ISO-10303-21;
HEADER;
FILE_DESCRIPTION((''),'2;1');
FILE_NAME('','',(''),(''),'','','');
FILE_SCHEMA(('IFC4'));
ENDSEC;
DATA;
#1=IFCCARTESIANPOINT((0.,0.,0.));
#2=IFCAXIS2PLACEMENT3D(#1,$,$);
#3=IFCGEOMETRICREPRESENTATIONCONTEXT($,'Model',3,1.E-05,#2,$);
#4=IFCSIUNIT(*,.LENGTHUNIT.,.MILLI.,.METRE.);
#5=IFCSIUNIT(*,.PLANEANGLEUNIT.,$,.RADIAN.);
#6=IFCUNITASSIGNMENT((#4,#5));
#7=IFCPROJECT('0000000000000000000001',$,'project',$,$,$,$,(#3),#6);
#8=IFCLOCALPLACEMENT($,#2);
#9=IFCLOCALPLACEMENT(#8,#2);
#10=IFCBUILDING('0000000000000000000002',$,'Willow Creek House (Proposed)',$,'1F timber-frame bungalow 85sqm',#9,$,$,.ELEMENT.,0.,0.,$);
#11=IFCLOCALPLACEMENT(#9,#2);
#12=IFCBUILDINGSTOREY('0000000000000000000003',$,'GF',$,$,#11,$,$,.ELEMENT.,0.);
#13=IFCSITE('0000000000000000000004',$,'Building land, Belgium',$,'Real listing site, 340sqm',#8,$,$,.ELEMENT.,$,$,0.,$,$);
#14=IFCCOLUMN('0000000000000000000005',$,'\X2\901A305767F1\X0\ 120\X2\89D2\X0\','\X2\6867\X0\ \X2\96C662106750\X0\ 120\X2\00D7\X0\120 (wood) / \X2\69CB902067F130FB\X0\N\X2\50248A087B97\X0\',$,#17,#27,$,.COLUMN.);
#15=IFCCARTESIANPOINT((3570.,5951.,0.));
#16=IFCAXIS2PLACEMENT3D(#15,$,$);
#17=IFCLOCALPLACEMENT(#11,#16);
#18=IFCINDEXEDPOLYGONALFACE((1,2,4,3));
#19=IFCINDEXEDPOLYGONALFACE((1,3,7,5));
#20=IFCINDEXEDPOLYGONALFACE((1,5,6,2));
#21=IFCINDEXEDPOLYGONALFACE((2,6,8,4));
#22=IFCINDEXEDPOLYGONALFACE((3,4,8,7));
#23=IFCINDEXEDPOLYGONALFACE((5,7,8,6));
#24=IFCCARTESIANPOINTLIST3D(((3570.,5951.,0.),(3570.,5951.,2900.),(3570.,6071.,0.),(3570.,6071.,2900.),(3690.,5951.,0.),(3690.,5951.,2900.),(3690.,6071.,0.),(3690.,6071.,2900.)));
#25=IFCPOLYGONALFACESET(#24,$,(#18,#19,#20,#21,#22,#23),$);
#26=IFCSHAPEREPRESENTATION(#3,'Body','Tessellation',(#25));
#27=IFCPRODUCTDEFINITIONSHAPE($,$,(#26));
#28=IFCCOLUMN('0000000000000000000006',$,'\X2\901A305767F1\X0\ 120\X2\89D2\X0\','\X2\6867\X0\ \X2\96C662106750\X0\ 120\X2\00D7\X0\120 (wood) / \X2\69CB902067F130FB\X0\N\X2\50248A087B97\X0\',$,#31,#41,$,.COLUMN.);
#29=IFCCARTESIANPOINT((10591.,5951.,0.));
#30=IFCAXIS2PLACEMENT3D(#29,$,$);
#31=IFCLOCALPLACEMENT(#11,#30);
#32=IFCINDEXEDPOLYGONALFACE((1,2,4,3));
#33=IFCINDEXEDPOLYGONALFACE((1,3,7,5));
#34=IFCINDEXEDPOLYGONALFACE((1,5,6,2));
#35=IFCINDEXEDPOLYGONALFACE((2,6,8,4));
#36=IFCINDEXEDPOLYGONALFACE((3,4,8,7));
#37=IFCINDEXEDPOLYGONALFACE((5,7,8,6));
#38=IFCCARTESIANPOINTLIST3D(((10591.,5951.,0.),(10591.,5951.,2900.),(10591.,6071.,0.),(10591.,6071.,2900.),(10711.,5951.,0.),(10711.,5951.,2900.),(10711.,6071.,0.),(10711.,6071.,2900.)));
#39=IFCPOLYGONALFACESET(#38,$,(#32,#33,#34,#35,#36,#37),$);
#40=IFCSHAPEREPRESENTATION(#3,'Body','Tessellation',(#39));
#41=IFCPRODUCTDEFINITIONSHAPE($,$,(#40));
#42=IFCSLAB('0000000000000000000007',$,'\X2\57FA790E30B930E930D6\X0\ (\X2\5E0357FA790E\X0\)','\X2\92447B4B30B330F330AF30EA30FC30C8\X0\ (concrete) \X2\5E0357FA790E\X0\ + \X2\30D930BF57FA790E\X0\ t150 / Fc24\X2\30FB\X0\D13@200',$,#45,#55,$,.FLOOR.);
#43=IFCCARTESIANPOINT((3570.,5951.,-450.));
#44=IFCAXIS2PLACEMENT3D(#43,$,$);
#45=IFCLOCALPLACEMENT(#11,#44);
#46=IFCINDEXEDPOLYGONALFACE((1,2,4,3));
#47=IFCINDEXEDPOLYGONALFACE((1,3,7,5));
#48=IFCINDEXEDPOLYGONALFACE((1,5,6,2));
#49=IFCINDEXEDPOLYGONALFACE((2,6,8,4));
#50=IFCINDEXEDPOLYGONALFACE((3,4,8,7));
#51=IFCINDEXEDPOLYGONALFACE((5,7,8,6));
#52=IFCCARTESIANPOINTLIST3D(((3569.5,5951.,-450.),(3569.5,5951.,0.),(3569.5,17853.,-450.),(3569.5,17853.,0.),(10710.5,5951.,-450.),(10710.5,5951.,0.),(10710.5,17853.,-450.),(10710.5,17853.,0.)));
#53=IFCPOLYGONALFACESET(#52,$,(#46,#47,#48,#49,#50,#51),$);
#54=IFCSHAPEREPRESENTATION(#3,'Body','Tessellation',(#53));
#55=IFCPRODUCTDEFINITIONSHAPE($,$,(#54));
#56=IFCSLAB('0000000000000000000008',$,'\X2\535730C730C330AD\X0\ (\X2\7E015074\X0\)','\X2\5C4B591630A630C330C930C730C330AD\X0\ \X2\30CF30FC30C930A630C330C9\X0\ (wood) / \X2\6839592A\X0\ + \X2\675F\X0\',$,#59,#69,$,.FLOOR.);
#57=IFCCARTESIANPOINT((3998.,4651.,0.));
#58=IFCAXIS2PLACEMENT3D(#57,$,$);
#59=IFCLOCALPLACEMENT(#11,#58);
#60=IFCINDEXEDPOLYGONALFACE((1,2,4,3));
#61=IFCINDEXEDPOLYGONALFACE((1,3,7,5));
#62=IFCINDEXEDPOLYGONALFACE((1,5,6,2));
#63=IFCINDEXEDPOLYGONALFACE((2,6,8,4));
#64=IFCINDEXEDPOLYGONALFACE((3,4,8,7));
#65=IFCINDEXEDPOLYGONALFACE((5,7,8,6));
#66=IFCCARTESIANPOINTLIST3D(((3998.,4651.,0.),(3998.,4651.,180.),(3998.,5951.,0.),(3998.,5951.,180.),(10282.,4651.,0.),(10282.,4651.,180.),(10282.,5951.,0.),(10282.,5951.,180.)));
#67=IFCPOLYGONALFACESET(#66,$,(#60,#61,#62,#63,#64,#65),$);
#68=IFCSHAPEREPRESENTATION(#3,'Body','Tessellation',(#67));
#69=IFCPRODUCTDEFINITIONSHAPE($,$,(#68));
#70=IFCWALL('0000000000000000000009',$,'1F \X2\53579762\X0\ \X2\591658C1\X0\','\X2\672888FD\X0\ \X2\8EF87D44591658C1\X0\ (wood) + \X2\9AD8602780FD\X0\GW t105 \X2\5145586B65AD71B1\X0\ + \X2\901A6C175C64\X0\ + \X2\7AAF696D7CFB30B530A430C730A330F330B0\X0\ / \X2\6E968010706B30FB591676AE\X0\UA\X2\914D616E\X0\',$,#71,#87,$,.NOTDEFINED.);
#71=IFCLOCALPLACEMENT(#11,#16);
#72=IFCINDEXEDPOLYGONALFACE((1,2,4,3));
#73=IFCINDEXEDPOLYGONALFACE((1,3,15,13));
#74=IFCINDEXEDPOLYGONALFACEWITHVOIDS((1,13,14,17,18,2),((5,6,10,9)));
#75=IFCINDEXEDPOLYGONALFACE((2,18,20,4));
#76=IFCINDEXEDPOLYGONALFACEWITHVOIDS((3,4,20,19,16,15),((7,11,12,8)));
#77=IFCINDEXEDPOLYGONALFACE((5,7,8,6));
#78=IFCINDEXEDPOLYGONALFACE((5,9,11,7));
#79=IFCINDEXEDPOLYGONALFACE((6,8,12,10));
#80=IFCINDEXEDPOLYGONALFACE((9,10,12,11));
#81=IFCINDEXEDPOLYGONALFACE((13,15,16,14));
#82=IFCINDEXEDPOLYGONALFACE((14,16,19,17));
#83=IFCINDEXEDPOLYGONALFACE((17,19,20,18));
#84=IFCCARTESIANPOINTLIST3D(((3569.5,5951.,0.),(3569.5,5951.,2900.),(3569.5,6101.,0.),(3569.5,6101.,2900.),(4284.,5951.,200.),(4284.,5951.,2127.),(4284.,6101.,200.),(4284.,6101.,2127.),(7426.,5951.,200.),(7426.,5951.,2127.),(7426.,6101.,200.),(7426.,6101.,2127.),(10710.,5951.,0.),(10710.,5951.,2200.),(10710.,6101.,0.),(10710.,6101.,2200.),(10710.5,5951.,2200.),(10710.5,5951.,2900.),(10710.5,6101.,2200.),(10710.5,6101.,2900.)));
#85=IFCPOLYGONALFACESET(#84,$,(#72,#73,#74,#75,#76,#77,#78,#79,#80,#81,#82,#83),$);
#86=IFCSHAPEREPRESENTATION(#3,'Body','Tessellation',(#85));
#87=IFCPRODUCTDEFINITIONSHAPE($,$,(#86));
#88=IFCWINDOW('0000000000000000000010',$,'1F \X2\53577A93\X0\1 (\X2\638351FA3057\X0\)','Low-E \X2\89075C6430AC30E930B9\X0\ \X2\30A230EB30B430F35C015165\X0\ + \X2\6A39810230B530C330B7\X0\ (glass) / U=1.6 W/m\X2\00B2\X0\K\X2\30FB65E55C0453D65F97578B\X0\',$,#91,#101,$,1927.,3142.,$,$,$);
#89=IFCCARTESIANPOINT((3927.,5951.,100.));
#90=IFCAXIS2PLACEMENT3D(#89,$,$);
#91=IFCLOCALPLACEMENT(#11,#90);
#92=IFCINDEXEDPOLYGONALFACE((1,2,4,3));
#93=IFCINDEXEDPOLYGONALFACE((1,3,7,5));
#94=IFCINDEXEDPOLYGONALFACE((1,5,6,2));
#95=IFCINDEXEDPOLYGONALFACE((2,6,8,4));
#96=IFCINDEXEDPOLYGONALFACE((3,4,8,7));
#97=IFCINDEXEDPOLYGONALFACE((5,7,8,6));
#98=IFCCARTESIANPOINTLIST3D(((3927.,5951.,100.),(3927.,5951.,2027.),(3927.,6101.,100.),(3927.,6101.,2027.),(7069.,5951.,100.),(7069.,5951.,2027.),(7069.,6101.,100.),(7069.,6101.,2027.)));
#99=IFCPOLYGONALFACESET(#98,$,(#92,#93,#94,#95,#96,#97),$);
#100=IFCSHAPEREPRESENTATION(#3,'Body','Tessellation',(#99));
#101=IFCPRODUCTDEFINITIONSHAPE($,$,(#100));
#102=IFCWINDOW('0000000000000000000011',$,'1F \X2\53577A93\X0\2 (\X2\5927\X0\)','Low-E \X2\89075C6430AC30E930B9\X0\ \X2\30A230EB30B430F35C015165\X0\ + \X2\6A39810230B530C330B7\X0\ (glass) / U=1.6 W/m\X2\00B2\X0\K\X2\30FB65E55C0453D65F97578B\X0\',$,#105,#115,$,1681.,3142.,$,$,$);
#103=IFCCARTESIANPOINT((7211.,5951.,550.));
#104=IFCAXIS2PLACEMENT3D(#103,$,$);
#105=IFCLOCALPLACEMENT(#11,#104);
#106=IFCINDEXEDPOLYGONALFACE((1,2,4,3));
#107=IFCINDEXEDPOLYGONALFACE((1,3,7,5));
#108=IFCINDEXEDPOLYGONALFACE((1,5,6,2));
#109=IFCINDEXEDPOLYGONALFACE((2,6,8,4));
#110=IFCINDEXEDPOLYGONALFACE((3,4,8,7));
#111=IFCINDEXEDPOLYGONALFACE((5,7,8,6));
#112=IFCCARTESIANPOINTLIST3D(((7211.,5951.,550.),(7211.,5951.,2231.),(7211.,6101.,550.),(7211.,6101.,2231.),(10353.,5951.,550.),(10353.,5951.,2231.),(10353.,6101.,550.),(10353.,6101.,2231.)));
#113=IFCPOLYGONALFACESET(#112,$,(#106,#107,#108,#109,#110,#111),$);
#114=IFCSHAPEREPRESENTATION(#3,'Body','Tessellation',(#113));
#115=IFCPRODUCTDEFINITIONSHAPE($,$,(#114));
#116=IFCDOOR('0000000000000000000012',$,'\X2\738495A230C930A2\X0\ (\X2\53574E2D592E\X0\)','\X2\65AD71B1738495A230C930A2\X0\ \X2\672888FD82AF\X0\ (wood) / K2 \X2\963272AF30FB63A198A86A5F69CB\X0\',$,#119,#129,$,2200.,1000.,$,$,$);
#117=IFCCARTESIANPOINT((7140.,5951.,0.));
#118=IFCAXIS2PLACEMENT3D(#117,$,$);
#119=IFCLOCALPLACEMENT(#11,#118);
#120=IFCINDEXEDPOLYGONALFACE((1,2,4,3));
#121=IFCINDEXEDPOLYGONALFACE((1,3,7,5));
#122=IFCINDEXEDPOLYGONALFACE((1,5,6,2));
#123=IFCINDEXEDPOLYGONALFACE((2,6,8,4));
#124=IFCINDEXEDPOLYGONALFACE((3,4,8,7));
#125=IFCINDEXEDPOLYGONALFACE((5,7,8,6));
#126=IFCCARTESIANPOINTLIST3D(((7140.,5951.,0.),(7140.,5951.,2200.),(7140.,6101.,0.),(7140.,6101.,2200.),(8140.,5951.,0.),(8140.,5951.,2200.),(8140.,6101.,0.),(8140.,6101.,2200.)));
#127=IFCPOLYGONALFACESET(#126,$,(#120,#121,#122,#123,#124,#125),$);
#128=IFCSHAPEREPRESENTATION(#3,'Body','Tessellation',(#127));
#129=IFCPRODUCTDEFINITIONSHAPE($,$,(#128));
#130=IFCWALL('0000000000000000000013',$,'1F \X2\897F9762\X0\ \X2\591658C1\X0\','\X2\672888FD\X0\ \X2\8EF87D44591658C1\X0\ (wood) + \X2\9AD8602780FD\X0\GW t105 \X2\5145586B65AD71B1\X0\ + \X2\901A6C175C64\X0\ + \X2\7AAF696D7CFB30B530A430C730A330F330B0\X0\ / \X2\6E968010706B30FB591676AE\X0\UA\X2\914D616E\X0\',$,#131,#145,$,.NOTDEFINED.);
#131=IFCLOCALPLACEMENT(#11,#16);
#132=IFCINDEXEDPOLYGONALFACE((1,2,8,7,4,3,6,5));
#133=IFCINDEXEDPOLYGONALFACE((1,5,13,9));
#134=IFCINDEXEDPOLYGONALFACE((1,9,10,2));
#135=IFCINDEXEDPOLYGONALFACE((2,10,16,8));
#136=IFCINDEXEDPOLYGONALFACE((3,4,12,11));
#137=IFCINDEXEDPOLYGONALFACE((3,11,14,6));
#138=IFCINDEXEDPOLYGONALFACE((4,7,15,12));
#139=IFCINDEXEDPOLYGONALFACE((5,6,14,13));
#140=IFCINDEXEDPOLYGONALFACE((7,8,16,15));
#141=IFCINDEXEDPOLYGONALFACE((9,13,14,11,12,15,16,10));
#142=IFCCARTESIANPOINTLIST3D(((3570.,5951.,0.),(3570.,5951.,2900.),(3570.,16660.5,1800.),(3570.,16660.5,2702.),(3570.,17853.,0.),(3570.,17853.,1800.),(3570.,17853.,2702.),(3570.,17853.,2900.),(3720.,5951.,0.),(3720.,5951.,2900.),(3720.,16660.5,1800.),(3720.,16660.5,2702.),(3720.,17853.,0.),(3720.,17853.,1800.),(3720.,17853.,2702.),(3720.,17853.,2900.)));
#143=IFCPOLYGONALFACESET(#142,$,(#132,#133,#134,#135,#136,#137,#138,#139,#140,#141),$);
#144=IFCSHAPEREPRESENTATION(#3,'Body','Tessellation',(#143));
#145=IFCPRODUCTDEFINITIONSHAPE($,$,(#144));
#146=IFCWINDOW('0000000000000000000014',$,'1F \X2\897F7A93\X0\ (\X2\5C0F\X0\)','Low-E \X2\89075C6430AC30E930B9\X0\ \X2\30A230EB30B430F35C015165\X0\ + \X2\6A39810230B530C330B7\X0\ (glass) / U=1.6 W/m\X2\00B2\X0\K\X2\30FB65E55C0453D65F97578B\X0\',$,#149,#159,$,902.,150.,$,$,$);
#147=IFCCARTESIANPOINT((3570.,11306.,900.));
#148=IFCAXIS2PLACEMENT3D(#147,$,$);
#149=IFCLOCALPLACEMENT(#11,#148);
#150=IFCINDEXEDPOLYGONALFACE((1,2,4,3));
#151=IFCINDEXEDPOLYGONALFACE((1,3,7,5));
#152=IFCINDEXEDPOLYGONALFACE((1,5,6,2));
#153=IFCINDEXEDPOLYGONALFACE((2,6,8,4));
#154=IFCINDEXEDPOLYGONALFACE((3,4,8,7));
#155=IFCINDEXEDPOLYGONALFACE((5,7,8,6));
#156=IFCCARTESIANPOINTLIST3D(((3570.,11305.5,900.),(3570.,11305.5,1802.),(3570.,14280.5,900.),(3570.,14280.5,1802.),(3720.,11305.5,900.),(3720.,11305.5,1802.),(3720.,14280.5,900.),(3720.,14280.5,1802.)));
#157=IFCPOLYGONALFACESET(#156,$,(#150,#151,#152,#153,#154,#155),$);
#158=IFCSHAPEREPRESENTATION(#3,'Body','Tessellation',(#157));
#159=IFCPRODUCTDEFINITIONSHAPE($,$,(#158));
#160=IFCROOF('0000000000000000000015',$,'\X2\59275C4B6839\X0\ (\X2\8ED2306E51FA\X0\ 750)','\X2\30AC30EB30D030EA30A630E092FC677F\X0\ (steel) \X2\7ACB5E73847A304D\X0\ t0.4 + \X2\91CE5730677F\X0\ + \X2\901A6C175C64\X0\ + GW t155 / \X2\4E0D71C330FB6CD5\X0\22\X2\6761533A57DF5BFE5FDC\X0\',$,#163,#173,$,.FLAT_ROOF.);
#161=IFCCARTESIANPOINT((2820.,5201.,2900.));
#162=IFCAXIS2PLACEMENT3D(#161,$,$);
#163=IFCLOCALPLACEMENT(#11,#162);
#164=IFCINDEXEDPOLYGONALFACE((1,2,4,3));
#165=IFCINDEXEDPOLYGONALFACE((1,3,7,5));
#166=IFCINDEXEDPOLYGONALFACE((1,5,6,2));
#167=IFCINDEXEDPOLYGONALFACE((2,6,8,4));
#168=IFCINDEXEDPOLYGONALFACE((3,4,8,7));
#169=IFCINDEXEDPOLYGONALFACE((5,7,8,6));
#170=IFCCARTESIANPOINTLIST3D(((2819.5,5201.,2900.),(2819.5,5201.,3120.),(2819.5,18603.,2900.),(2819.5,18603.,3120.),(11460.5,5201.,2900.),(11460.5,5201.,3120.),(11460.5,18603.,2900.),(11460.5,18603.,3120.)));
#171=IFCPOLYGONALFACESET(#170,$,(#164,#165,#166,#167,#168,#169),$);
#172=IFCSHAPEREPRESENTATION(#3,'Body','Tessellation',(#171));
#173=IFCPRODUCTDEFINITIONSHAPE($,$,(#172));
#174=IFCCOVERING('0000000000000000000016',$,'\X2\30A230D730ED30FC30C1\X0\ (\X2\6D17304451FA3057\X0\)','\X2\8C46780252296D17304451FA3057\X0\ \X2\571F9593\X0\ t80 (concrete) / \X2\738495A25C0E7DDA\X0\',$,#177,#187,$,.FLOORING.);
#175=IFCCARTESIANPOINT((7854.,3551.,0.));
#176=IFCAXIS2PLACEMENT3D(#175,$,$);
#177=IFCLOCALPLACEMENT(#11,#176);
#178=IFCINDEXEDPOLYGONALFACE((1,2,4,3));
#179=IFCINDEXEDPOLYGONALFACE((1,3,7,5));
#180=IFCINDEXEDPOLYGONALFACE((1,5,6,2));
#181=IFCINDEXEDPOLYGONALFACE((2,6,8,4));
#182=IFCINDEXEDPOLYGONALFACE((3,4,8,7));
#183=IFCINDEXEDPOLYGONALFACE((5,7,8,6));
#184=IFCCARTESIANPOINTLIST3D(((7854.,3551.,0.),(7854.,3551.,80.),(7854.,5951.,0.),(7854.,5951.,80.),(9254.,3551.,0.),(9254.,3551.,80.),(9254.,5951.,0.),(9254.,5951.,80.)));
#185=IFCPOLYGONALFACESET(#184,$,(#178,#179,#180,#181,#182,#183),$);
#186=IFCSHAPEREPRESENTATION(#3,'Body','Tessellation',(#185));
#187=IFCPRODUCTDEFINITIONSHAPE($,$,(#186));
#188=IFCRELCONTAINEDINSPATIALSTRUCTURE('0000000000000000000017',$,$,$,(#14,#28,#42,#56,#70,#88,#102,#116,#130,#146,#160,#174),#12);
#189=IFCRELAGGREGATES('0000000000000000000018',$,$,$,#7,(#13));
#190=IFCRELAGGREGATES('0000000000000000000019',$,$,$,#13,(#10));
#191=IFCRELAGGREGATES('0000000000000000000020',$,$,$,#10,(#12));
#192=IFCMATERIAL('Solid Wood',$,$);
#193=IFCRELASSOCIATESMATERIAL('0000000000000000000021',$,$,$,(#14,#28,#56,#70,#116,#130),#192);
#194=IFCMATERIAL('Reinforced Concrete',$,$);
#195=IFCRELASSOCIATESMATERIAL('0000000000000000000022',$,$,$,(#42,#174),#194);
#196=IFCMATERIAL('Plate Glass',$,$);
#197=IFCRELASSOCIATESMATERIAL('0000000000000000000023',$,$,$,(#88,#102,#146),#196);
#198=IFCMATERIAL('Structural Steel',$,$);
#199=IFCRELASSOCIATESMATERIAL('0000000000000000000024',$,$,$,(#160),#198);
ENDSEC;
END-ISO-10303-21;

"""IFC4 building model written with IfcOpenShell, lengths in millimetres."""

from ifc_helpers import new_model, si_unit, frame, frame_2d, origin, place, context, project, spatial, rectangle, extrude, material, element, fill, save


model = new_model("IFC4")

# Units and contexts
model_context = context("Model", 3, precision=1e-05, world=origin())
ifc_project = project(units=[si_unit("LENGTHUNIT", "METRE", prefix="MILLI"), si_unit("PLANEANGLEUNIT", "RADIAN")], contexts=[model_context])

# Site, building, storey
site_placement = place(None, origin())
site = spatial("IfcSite", under=ifc_project, at=site_placement, Name="Building land, Belgium", ObjectType="Real listing site, 340sqm", CompositionType="ELEMENT", RefElevation=0.0)
building_placement = place(site_placement, origin())
building = spatial("IfcBuilding", under=site, at=building_placement, Name="Willow Creek House (Proposed)", ObjectType="1F timber-frame bungalow 85sqm", CompositionType="ELEMENT", ElevationOfRefHeight=0.0, ElevationOfTerrain=0.0)
storey_placement = place(building_placement, origin())
storey = spatial("IfcBuildingStorey", under=building, at=storey_placement, Name="GF", CompositionType="ELEMENT", Elevation=0.0)

# Columns
ifc_material_1 = material(Name="Solid Wood")
column_1_placement = place(storey_placement, frame((3570.0, 5951.0, 0.0)))
element("IfcColumn", 1, at=column_1_placement, inside=storey, material=ifc_material_1, Name="通し柱 120角", Description="桧 集成材 120×120 (wood) / 構造柱・N値計算", PredefinedType="COLUMN", context=model_context, shape_type="SweptSolid", body=[
    extrude(rectangle(XDim=120.0, YDim=120.0, at=frame_2d((60.0, 60.0))), frame((3570.0, 5951.0, 0.0)), (0.0, 0.0, 1.0), 2900.0),
])
column_2_placement = place(storey_placement, frame((10591.0, 5951.0, 0.0)))
element("IfcColumn", 2, at=column_2_placement, inside=storey, material=ifc_material_1, Name="通し柱 120角", Description="桧 集成材 120×120 (wood) / 構造柱・N値計算", PredefinedType="COLUMN", context=model_context, shape_type="SweptSolid", body=[
    extrude(rectangle(XDim=120.0, YDim=120.0, at=frame_2d((60.0, 60.0))), frame((10591.0, 5951.0, 0.0)), (0.0, 0.0, 1.0), 2900.0),
])

# Slabs
ifc_material_2 = material(Name="Reinforced Concrete")
slab_1_placement = place(storey_placement, frame((3570.0, 5951.0, -450.0)))
element("IfcSlab", 3, at=slab_1_placement, inside=storey, material=ifc_material_2, Name="基礎スラブ (布基礎)", Description="鉄筋コンクリート (concrete) 布基礎 + ベタ基礎 t150 / Fc24・D13@200", PredefinedType="FLOOR", context=model_context, shape_type="SweptSolid", body=[
    extrude(rectangle(XDim=7141.0, YDim=11902.0, at=frame_2d((3570.0, 5951.0))), frame((3570.0, 5951.0, -450.0)), (0.0, 0.0, 1.0), 450.0),
])
slab_2_placement = place(storey_placement, frame((3998.0, 4651.0, 0.0)))
element("IfcSlab", 4, at=slab_2_placement, inside=storey, material=ifc_material_1, Name="南デッキ (縁側)", Description="屋外ウッドデッキ ハードウッド (wood) / 根太 + 束", PredefinedType="FLOOR", context=model_context, shape_type="SweptSolid", body=[
    extrude(rectangle(XDim=6284.0, YDim=1300.0, at=frame_2d((3142.0, 650.0))), frame((3998.0, 4651.0, 0.0)), (0.0, 0.0, 1.0), 180.0),
])

# Wall, openings, windows, door
wall_1_placement = place(storey_placement, frame((3570.0, 5951.0, 0.0)))
wall_1 = element("IfcWall", 5, at=wall_1_placement, inside=storey, material=ifc_material_1, Name="1F 南面 外壁", Description="木製 軸組外壁 (wood) + 高性能GW t105 充填断熱 + 通気層 + 窯業系サイディング / 準耐火・外皮UA配慮", PredefinedType="NOTDEFINED", context=model_context, shape_type="SweptSolid", body=[
    extrude(rectangle(XDim=7141.0, YDim=150.0, at=frame_2d((3570.0, 75.0))), frame((3570.0, 5951.0, 0.0)), (0.0, 0.0, 1.0), 2900.0),
])
opening_1_placement = place(storey_placement, frame((3927.0, 5951.0, 100.0)))
opening_1 = element("IfcOpeningElement", 6, at=opening_1_placement, cuts=wall_1, PredefinedType="NOTDEFINED", context=model_context, shape_type="SweptSolid", body=[
    extrude(rectangle(XDim=3142.0, YDim=150.0, at=frame_2d((1571.0, 75.0))), frame((3927.0, 5951.0, 100.0)), (0.0, 0.0, 1.0), 1927.0),
])
opening_2_placement = place(storey_placement, frame((7211.0, 5951.0, 550.0)))
opening_2 = element("IfcOpeningElement", 7, at=opening_2_placement, cuts=wall_1, PredefinedType="NOTDEFINED", context=model_context, shape_type="SweptSolid", body=[
    extrude(rectangle(XDim=3142.0, YDim=150.0, at=frame_2d((1571.0, 75.0))), frame((7211.0, 5951.0, 550.0)), (0.0, 0.0, 1.0), 1681.0),
])
opening_3_placement = place(storey_placement, frame((7140.0, 5951.0, 0.0)))
opening_3 = element("IfcOpeningElement", 8, at=opening_3_placement, cuts=wall_1, PredefinedType="NOTDEFINED", context=model_context, shape_type="SweptSolid", body=[
    extrude(rectangle(XDim=1000.0, YDim=150.0, at=frame_2d((500.0, 75.0))), frame((7140.0, 5951.0, 0.0)), (0.0, 0.0, 1.0), 2200.0),
])
ifc_material_3 = material(Name="Plate Glass")
window_1_placement = place(storey_placement, frame((3927.0, 5951.0, 100.0)))
window_1 = element("IfcWindow", 9, at=window_1_placement, inside=storey, material=ifc_material_3, Name="1F 南窓1 (掃出し)", Description="Low-E 複層ガラス アルゴン封入 + 樹脂サッシ (glass) / U=1.6 W/m²K・日射取得型", OverallHeight=1927.0, OverallWidth=3142.0, context=model_context, shape_type="SweptSolid", body=[
    extrude(rectangle(XDim=3142.0, YDim=150.0, at=frame_2d((1571.0, 75.0))), frame((3927.0, 5951.0, 100.0)), (0.0, 0.0, 1.0), 1927.0),
])
fill(opening_1, window_1)
window_2_placement = place(storey_placement, frame((7211.0, 5951.0, 550.0)))
window_2 = element("IfcWindow", 10, at=window_2_placement, inside=storey, material=ifc_material_3, Name="1F 南窓2 (大)", Description="Low-E 複層ガラス アルゴン封入 + 樹脂サッシ (glass) / U=1.6 W/m²K・日射取得型", OverallHeight=1681.0, OverallWidth=3142.0, context=model_context, shape_type="SweptSolid", body=[
    extrude(rectangle(XDim=3142.0, YDim=150.0, at=frame_2d((1571.0, 75.0))), frame((7211.0, 5951.0, 550.0)), (0.0, 0.0, 1.0), 1681.0),
])
fill(opening_2, window_2)
door_placement = place(storey_placement, frame((7140.0, 5951.0, 0.0)))
door = element("IfcDoor", 11, at=door_placement, inside=storey, material=ifc_material_1, Name="玄関ドア (南中央)", Description="断熱玄関ドア 木製芯 (wood) / K2 防犯・採風機構", OverallHeight=2200.0, OverallWidth=1000.0, context=model_context, shape_type="SweptSolid", body=[
    extrude(rectangle(XDim=1000.0, YDim=150.0, at=frame_2d((500.0, 75.0))), frame((7140.0, 5951.0, 0.0)), (0.0, 0.0, 1.0), 2200.0),
])
fill(opening_3, door)

# Wall, opening, window
wall_2_placement = place(storey_placement, frame((3570.0, 5951.0, 0.0)))
wall_2 = element("IfcWall", 12, at=wall_2_placement, inside=storey, material=ifc_material_1, Name="1F 西面 外壁", Description="木製 軸組外壁 (wood) + 高性能GW t105 充填断熱 + 通気層 + 窯業系サイディング / 準耐火・外皮UA配慮", PredefinedType="NOTDEFINED", context=model_context, shape_type="SweptSolid", body=[
    extrude(rectangle(XDim=150.0, YDim=11902.0, at=frame_2d((75.0, 5951.0))), frame((3570.0, 5951.0, 0.0)), (0.0, 0.0, 1.0), 2900.0),
])
opening_4_placement = place(storey_placement, frame((3570.0, 11306.0, 900.0)))
opening_4 = element("IfcOpeningElement", 13, at=opening_4_placement, cuts=wall_2, PredefinedType="NOTDEFINED", context=model_context, shape_type="SweptSolid", body=[
    extrude(rectangle(XDim=150.0, YDim=2975.0, at=frame_2d((75.0, 1487.0))), frame((3570.0, 11306.0, 900.0)), (0.0, 0.0, 1.0), 902.0),
])
window_3_placement = place(storey_placement, frame((3570.0, 11306.0, 900.0)))
window_3 = element("IfcWindow", 14, at=window_3_placement, inside=storey, material=ifc_material_3, Name="1F 西窓 (小)", Description="Low-E 複層ガラス アルゴン封入 + 樹脂サッシ (glass) / U=1.6 W/m²K・日射取得型", OverallHeight=902.0, OverallWidth=150.0, context=model_context, shape_type="SweptSolid", body=[
    extrude(rectangle(XDim=150.0, YDim=2975.0, at=frame_2d((75.0, 1487.0))), frame((3570.0, 11306.0, 900.0)), (0.0, 0.0, 1.0), 902.0),
])
fill(opening_4, window_3)

# Roof
ifc_material_4 = material(Name="Structural Steel")
roof_placement = place(storey_placement, frame((2820.0, 5201.0, 2900.0)))
element("IfcRoof", 15, at=roof_placement, inside=storey, material=ifc_material_4, Name="大屋根 (軒の出 750)", Description="ガルバリウム鋼板 (steel) 立平葺き t0.4 + 野地板 + 通気層 + GW t155 / 不燃・法22条区域対応", PredefinedType="FLAT_ROOF", context=model_context, shape_type="SweptSolid", body=[
    extrude(rectangle(XDim=8641.0, YDim=13402.0, at=frame_2d((4320.0, 6701.0))), frame((2820.0, 5201.0, 2900.0)), (0.0, 0.0, 1.0), 220.0),
])

# Covering
covering_1_placement = place(storey_placement, frame((7854.0, 3551.0, 0.0)))
element("IfcCovering", 16, at=covering_1_placement, inside=storey, material=ifc_material_2, Name="アプローチ (洗い出し)", Description="豆砂利洗い出し 土間 t80 (concrete) / 玄関導線", PredefinedType="FLOORING", context=model_context, shape_type="SweptSolid", body=[
    extrude(rectangle(XDim=1400.0, YDim=2400.0, at=frame_2d((700.0, 1200.0))), frame((7854.0, 3551.0, 0.0)), (0.0, 0.0, 1.0), 80.0),
])

save(model, "model.ifc")
